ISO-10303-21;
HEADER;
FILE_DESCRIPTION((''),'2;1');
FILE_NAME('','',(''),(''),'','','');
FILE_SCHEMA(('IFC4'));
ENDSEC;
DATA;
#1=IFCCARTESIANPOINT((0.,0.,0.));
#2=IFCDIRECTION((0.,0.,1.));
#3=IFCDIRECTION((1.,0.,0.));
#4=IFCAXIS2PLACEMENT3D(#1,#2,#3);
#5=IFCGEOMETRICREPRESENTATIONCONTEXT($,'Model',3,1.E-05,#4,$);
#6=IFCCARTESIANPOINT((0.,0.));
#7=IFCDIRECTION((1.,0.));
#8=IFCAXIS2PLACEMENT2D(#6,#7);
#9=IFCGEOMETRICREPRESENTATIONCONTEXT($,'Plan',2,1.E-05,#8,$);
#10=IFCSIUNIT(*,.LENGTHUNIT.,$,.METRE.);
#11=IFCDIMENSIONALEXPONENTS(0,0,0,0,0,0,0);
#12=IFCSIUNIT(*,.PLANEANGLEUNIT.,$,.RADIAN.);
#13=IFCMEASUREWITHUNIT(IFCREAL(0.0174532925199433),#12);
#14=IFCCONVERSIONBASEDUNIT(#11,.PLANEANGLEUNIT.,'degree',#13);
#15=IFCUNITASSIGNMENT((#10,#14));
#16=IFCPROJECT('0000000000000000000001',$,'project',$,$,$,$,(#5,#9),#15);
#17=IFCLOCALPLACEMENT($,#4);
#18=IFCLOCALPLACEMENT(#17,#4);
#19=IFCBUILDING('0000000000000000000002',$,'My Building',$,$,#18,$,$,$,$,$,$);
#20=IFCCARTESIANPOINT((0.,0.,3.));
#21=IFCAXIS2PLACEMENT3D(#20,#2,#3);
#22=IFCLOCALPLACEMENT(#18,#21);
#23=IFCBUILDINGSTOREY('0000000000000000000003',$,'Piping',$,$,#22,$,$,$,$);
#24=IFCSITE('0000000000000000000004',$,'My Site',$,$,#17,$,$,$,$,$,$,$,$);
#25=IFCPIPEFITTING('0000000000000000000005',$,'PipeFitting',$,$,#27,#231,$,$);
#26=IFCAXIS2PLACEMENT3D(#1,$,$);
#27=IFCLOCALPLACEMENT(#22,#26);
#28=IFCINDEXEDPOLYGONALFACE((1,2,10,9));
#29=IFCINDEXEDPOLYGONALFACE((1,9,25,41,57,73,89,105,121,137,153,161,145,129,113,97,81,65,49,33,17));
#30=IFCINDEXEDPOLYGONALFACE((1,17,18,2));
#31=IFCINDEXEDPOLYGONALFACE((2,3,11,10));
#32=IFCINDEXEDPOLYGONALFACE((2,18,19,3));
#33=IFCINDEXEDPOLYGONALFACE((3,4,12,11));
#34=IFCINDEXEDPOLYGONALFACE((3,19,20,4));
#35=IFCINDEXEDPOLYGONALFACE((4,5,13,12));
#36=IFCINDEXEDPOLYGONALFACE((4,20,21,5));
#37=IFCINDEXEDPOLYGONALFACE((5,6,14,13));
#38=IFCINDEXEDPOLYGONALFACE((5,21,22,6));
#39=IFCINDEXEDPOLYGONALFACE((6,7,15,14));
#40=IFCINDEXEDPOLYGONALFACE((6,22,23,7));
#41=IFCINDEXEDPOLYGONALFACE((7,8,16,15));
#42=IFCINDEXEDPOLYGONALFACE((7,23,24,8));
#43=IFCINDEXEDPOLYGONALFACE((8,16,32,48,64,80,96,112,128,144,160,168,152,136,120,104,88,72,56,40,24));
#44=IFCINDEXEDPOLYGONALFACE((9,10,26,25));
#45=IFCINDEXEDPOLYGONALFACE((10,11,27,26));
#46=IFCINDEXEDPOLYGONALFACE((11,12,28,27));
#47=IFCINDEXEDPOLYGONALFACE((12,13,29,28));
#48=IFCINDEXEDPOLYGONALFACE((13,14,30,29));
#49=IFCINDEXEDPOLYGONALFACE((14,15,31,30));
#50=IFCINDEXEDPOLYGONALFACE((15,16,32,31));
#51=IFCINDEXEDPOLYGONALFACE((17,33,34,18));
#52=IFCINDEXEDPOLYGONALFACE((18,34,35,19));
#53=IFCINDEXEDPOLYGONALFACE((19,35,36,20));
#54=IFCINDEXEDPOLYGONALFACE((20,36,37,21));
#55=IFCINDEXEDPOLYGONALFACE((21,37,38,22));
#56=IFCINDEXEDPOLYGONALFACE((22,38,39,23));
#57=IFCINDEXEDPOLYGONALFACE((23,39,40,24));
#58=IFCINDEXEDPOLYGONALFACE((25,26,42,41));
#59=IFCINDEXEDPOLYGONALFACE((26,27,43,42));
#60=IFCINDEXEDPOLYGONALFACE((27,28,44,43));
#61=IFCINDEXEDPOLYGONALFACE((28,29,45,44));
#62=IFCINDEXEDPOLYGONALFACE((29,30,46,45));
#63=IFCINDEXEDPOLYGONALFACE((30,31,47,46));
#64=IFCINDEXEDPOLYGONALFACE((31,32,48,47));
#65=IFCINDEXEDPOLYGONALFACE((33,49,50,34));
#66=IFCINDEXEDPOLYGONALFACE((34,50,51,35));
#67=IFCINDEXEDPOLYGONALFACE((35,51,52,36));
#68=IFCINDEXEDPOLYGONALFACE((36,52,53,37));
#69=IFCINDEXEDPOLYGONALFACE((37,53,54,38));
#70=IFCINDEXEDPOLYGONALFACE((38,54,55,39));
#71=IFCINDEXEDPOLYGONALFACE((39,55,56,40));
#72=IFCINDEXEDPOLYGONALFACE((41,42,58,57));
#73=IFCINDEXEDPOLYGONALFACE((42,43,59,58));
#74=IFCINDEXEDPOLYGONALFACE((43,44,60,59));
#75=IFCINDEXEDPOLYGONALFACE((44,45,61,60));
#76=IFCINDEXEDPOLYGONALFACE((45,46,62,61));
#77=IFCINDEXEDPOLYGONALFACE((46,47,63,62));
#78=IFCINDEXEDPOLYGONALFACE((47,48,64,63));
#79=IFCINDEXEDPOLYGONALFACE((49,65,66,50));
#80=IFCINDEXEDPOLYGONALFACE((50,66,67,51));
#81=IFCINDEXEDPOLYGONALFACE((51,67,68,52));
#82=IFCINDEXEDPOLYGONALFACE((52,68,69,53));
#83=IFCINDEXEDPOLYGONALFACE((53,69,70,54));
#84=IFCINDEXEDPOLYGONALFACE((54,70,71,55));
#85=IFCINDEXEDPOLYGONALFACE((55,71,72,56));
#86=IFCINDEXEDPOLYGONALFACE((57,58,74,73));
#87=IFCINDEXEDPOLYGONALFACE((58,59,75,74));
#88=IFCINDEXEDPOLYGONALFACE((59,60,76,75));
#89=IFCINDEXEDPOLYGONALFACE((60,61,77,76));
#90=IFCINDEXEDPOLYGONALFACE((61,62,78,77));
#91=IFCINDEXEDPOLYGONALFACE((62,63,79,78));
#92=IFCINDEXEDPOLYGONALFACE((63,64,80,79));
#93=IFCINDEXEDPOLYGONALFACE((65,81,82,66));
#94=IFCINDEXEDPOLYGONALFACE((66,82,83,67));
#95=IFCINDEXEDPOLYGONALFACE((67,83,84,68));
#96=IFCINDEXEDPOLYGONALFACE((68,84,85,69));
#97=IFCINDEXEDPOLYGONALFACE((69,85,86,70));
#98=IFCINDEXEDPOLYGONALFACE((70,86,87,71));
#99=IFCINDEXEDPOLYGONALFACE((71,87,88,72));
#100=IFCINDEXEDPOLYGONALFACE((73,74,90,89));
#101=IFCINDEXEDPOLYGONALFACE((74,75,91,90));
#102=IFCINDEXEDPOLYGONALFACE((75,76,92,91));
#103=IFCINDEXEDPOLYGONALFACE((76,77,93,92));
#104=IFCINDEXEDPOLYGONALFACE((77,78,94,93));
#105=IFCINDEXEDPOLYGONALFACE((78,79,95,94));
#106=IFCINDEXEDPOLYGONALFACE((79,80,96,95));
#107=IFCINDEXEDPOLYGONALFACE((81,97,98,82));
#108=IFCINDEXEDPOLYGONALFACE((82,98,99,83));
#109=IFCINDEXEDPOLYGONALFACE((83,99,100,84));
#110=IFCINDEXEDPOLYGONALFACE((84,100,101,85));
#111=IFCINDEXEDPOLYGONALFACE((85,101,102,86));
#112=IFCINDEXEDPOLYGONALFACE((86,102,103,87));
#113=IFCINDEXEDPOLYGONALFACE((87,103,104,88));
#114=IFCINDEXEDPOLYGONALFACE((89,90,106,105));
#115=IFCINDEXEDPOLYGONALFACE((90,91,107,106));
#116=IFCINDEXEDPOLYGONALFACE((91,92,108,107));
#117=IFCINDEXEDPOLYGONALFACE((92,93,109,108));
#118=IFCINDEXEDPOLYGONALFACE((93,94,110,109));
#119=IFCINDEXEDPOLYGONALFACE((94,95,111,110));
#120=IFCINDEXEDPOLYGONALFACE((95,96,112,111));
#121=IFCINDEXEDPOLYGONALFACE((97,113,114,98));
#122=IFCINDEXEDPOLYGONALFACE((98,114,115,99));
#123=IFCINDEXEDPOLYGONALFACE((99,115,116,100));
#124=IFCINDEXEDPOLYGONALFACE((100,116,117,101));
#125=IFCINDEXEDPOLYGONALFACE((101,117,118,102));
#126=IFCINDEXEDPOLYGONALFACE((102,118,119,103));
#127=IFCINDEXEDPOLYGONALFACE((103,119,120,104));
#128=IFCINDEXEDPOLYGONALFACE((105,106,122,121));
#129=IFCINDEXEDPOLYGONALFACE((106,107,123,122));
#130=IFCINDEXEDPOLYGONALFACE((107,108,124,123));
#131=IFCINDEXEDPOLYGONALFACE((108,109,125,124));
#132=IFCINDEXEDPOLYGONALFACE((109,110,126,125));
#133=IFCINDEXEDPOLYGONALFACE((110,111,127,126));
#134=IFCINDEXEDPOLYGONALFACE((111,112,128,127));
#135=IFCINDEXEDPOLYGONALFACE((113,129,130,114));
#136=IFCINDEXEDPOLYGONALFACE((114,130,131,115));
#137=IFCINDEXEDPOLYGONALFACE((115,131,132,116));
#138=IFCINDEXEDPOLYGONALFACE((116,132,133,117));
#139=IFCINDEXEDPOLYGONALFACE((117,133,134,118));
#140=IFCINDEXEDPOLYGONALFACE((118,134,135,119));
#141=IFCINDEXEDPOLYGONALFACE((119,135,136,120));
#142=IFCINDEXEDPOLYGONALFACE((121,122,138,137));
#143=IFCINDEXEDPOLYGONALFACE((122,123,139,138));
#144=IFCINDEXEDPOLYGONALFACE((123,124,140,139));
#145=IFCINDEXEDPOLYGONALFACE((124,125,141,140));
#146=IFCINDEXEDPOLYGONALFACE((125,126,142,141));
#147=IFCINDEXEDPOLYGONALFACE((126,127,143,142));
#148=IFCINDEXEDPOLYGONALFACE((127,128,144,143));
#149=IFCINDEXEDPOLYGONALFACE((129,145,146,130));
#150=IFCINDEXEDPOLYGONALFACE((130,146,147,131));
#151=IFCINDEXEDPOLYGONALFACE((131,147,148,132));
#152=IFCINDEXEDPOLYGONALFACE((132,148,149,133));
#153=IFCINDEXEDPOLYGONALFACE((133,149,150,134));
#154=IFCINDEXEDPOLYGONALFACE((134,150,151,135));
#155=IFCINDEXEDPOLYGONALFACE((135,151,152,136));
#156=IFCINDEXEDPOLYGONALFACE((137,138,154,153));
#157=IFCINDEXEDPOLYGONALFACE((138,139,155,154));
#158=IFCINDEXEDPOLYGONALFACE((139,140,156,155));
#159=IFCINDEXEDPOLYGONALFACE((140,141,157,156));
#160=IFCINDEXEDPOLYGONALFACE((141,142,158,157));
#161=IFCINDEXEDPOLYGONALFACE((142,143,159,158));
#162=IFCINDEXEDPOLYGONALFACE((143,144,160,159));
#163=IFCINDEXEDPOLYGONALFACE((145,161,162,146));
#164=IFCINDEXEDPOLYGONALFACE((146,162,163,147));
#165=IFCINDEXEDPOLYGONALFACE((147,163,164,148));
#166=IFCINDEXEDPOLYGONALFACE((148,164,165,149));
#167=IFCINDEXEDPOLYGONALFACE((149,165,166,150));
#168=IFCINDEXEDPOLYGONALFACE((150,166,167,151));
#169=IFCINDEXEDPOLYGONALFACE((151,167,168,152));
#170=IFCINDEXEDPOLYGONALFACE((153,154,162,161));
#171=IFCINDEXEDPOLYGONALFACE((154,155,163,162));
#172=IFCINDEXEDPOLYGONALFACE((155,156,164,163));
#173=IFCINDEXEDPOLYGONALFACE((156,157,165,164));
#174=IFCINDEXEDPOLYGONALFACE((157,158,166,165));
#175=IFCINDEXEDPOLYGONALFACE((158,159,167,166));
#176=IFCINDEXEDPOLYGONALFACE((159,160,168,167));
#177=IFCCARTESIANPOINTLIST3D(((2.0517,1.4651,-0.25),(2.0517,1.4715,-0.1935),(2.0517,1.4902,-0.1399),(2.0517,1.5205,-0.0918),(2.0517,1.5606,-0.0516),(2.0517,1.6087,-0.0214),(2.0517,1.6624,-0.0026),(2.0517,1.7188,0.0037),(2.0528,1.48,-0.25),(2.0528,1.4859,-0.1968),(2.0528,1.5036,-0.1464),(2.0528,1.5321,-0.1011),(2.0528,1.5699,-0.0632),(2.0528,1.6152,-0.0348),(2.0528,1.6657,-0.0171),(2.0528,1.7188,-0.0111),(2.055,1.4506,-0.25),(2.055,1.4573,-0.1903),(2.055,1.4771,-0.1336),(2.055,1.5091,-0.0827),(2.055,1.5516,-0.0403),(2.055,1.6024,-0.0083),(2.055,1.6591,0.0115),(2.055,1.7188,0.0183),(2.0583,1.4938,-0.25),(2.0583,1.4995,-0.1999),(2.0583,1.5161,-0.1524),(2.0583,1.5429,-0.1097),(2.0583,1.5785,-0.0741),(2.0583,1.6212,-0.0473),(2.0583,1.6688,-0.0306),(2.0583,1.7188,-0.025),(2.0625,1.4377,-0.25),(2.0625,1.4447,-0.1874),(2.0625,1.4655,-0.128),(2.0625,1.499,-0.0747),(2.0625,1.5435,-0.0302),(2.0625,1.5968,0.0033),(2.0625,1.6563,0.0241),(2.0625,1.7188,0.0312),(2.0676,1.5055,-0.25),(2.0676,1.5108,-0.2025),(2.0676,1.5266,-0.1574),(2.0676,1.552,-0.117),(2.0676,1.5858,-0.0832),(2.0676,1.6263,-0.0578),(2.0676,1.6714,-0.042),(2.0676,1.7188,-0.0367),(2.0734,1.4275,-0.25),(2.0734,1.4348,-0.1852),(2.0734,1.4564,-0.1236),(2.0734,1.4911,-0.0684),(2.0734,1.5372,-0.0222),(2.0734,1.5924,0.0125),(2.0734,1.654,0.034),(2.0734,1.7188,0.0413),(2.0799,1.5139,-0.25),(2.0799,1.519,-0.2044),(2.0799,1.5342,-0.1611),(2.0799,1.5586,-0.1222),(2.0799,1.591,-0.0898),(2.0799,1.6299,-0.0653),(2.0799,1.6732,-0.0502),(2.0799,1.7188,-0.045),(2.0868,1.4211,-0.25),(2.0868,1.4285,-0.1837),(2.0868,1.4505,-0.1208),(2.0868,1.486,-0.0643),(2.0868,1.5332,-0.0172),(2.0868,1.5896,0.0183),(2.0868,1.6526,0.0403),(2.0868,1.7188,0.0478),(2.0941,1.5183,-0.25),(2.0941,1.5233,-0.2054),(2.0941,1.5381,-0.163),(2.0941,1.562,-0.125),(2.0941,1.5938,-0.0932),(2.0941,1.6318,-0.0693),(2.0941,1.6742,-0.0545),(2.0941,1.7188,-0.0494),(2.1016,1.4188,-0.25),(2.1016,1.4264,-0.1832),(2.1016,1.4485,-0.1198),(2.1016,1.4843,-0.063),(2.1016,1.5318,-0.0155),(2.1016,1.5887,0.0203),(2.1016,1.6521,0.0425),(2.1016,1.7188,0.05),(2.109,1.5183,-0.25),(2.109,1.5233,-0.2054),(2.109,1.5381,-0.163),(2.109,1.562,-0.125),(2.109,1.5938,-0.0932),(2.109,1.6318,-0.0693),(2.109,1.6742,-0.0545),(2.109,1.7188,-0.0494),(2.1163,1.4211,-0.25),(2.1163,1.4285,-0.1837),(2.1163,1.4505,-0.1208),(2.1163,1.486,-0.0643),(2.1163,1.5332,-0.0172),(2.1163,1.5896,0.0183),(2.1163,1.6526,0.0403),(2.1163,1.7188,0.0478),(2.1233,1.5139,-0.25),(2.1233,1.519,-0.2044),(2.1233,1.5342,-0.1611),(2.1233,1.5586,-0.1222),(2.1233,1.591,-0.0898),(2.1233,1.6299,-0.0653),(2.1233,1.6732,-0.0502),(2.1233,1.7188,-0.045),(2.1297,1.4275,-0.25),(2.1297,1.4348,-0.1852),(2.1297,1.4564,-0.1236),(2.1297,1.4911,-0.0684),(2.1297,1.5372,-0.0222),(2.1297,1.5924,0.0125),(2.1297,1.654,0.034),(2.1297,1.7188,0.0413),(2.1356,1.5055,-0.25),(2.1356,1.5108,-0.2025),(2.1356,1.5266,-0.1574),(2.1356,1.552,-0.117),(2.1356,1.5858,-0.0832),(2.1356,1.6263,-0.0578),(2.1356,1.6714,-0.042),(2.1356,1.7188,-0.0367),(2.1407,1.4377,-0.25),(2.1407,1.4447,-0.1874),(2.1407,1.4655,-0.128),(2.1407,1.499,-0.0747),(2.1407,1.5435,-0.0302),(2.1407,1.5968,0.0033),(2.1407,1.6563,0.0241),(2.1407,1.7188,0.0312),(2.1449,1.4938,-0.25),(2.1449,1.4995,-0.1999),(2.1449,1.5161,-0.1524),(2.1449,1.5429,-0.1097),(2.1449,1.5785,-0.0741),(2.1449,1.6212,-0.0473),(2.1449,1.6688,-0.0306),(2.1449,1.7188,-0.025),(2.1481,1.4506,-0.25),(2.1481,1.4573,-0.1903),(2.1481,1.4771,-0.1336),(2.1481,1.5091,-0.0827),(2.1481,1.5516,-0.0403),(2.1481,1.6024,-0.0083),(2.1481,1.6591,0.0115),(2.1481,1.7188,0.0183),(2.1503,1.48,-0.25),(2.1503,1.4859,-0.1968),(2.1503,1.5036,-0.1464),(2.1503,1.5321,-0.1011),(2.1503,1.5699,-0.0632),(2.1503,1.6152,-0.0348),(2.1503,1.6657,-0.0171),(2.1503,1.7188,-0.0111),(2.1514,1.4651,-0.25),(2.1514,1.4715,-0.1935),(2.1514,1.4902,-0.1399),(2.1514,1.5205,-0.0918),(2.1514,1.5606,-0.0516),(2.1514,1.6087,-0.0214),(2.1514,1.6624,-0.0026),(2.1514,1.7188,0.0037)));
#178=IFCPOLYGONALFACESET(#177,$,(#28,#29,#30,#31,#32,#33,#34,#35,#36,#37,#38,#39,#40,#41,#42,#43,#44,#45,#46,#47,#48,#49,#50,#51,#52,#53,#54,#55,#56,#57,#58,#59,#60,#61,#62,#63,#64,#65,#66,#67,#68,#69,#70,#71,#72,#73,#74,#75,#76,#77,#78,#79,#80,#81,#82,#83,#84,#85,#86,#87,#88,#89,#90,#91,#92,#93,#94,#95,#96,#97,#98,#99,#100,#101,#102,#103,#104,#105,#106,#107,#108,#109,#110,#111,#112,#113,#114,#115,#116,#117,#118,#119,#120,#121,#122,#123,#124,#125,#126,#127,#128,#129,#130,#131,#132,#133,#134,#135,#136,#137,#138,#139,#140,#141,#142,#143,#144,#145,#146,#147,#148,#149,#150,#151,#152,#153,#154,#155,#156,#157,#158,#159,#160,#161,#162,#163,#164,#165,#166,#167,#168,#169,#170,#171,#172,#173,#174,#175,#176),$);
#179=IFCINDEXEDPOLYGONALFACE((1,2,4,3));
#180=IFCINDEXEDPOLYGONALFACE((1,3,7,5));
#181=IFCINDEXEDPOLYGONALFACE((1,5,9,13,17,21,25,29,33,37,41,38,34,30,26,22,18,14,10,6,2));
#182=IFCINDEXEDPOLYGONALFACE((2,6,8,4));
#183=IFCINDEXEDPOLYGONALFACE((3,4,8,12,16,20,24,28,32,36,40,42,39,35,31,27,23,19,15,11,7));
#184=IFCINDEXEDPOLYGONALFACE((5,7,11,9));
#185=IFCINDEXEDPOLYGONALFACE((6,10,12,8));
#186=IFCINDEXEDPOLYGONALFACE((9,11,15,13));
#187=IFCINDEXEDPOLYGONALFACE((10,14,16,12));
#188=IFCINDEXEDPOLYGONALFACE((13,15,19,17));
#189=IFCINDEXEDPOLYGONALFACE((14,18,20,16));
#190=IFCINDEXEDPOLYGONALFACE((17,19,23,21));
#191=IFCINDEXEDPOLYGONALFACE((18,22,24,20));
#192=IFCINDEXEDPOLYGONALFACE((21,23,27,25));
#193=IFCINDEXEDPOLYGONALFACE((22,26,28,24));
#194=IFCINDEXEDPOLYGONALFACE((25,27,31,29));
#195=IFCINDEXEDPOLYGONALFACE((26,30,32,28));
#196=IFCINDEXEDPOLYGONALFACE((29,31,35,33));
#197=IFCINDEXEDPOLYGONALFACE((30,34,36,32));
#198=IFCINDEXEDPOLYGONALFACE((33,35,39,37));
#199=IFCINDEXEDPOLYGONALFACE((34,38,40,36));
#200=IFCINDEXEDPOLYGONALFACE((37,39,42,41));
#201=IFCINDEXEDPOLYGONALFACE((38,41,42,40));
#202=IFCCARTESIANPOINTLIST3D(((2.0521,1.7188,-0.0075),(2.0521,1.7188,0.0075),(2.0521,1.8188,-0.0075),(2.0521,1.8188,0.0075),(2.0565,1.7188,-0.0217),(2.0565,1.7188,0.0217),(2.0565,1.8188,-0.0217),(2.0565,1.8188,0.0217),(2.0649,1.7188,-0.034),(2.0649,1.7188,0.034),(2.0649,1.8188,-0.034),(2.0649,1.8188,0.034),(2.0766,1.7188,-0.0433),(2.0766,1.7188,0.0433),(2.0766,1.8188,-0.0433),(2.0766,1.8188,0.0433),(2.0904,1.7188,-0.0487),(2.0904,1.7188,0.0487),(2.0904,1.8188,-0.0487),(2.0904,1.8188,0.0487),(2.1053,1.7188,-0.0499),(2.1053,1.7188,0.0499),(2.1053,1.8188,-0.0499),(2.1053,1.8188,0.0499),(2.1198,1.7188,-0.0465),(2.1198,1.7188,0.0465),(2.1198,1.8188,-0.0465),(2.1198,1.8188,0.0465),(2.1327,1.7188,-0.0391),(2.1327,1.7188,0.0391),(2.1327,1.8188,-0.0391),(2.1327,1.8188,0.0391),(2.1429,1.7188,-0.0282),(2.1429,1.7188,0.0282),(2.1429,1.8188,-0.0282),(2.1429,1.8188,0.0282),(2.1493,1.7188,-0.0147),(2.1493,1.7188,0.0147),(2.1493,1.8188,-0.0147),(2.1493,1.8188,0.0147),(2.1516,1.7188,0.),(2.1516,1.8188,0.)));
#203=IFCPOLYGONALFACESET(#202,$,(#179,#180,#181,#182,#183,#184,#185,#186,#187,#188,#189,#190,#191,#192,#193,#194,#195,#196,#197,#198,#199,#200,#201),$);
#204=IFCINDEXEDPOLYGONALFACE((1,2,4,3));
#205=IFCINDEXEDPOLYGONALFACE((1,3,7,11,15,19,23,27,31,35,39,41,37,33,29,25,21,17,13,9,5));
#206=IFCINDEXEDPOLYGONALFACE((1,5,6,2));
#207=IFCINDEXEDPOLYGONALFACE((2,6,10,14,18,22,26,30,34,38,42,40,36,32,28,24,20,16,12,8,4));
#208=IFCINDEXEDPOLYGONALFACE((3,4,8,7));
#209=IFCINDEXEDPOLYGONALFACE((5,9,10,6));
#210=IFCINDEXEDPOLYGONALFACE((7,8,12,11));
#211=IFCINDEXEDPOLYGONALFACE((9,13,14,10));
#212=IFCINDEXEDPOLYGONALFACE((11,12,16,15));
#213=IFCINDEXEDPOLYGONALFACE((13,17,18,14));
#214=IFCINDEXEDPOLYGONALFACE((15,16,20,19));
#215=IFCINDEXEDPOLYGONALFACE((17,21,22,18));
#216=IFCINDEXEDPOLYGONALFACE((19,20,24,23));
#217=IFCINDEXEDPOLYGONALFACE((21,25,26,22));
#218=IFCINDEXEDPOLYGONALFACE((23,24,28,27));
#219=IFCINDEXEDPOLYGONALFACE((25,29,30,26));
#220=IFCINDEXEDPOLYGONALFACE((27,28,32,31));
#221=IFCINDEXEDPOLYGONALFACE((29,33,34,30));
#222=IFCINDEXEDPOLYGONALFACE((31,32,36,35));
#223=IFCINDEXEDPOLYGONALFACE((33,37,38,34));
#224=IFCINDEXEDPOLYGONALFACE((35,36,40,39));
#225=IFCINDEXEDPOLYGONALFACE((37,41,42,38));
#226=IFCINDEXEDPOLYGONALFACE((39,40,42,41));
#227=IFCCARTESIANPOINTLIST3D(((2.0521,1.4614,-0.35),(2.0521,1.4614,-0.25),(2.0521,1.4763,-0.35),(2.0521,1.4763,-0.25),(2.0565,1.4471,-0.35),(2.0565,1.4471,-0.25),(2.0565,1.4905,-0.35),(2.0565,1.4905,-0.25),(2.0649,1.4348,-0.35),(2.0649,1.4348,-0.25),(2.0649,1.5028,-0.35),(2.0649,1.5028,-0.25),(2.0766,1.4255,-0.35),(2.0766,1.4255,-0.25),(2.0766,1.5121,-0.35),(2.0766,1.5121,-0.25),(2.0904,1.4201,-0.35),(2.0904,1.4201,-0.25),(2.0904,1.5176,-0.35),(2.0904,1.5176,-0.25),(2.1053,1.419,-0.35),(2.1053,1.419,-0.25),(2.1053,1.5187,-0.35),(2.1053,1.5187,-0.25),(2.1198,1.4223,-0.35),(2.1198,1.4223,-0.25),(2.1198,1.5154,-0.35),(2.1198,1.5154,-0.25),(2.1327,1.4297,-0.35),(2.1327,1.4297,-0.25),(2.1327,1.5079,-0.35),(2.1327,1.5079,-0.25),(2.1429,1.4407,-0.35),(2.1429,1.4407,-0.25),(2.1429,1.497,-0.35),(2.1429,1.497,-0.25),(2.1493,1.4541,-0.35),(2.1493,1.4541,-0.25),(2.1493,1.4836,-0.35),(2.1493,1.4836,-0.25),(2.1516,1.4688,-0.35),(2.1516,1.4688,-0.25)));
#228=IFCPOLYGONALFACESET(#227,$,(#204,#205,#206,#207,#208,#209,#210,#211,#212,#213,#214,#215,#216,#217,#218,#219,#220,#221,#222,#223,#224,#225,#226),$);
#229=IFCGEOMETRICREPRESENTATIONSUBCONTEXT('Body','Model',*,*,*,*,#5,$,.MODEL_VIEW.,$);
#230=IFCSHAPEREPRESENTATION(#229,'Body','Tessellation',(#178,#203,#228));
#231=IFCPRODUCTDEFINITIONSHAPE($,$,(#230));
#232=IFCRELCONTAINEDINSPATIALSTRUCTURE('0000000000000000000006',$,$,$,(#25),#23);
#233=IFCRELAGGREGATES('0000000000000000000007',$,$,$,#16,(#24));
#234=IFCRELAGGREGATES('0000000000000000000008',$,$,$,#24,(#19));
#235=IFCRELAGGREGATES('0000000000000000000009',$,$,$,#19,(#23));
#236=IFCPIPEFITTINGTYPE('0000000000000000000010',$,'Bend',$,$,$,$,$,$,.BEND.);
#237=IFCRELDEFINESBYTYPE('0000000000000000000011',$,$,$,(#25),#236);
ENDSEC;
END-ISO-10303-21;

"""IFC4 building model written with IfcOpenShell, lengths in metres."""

from ifc_helpers import new_model, entity, si_unit, converted_unit, frame, origin_with_axes, origin_2d_with_axis, place, context, subcontext, project, spatial, circle, extrude, source, transform, mapped, type_object, type_shapes, element, save


model = new_model("IFC4")

# Units and contexts
model_context = context("Model", 3, precision=1e-05, world=origin_with_axes())
plan_context = context("Plan", 2, precision=1e-05, world=origin_2d_with_axis())
body_context = subcontext(model_context, "Body", "Model", "MODEL_VIEW")
ifc_project = project(units=[si_unit("LENGTHUNIT", "METRE"), converted_unit("PLANEANGLEUNIT", "degree", entity("IfcReal", 0.0174532925199433), si_unit("PLANEANGLEUNIT", "RADIAN"), dimensions=[0, 0, 0, 0, 0, 0, 0])], contexts=[model_context, plan_context])

# Site, building, storey
site_placement = place(None, origin_with_axes())
site = spatial("IfcSite", under=ifc_project, at=site_placement, Name="My Site")
building_placement = place(site_placement, origin_with_axes())
building = spatial("IfcBuilding", under=site, at=building_placement, Name="My Building")
storey_placement = place(building_placement, frame((0.0, 0.0, 3.0), z_axis=(0.0, 0.0, 1.0), x_axis=(1.0, 0.0, 0.0)))
storey = spatial("IfcBuildingStorey", under=building, at=storey_placement, Name="Piping")

# Pipe fitting
pipe_fitting_type = type_object("IfcPipeFittingType", Name="Bend", PredefinedType="BEND")
shared_shape = source(origin_with_axes(), body_context, "Body", "SolidModel", [
    entity("IfcSweptDiskSolid", entity("IfcIndexedPolyCurve", entity("IfcCartesianPointList3D", [[0.0, 0.0, -0.1], [0.0, 0.0732, -0.2768], [0.0, 0.25, -0.35]]), [entity("IfcArcIndex", [1, 2, 3])]), 0.05),
    extrude(circle(Radius=0.05), origin_with_axes(), (0.0, 0.0, -1.0), 0.1),
    extrude(circle(Radius=0.05), frame((0.0, 0.25, -0.35), z_axis=(0.0, 1.0, 0.0), x_axis=(1.0, 0.0, 0.0)), (0.0, 0.0, 1.0), 0.1),
])
type_shapes(pipe_fitting_type, [shared_shape])
for number, where, z_axis, x_axis, name in (
    (1, (2.1016, 1.8188, 0.0), (0.0, 1.0, 0.0), (1.0, 0.0, 0.0), "PipeFitting"),
):
    element("IfcPipeFitting", number, at=place(storey_placement, frame(where, z_axis=z_axis, x_axis=x_axis)), inside=storey, type_object=pipe_fitting_type, Name=name, context=body_context, shape_type="MappedRepresentation", body=[
        mapped(shared_shape, transform((0.0, 0.0, 0.0), x_axis=(1.0, 0.0, 0.0), y_axis=(0.0, 1.0, 0.0), z_axis=(0.0, 0.0, 1.0), scale=1.0)),
    ])

save(model, "model.ifc")
